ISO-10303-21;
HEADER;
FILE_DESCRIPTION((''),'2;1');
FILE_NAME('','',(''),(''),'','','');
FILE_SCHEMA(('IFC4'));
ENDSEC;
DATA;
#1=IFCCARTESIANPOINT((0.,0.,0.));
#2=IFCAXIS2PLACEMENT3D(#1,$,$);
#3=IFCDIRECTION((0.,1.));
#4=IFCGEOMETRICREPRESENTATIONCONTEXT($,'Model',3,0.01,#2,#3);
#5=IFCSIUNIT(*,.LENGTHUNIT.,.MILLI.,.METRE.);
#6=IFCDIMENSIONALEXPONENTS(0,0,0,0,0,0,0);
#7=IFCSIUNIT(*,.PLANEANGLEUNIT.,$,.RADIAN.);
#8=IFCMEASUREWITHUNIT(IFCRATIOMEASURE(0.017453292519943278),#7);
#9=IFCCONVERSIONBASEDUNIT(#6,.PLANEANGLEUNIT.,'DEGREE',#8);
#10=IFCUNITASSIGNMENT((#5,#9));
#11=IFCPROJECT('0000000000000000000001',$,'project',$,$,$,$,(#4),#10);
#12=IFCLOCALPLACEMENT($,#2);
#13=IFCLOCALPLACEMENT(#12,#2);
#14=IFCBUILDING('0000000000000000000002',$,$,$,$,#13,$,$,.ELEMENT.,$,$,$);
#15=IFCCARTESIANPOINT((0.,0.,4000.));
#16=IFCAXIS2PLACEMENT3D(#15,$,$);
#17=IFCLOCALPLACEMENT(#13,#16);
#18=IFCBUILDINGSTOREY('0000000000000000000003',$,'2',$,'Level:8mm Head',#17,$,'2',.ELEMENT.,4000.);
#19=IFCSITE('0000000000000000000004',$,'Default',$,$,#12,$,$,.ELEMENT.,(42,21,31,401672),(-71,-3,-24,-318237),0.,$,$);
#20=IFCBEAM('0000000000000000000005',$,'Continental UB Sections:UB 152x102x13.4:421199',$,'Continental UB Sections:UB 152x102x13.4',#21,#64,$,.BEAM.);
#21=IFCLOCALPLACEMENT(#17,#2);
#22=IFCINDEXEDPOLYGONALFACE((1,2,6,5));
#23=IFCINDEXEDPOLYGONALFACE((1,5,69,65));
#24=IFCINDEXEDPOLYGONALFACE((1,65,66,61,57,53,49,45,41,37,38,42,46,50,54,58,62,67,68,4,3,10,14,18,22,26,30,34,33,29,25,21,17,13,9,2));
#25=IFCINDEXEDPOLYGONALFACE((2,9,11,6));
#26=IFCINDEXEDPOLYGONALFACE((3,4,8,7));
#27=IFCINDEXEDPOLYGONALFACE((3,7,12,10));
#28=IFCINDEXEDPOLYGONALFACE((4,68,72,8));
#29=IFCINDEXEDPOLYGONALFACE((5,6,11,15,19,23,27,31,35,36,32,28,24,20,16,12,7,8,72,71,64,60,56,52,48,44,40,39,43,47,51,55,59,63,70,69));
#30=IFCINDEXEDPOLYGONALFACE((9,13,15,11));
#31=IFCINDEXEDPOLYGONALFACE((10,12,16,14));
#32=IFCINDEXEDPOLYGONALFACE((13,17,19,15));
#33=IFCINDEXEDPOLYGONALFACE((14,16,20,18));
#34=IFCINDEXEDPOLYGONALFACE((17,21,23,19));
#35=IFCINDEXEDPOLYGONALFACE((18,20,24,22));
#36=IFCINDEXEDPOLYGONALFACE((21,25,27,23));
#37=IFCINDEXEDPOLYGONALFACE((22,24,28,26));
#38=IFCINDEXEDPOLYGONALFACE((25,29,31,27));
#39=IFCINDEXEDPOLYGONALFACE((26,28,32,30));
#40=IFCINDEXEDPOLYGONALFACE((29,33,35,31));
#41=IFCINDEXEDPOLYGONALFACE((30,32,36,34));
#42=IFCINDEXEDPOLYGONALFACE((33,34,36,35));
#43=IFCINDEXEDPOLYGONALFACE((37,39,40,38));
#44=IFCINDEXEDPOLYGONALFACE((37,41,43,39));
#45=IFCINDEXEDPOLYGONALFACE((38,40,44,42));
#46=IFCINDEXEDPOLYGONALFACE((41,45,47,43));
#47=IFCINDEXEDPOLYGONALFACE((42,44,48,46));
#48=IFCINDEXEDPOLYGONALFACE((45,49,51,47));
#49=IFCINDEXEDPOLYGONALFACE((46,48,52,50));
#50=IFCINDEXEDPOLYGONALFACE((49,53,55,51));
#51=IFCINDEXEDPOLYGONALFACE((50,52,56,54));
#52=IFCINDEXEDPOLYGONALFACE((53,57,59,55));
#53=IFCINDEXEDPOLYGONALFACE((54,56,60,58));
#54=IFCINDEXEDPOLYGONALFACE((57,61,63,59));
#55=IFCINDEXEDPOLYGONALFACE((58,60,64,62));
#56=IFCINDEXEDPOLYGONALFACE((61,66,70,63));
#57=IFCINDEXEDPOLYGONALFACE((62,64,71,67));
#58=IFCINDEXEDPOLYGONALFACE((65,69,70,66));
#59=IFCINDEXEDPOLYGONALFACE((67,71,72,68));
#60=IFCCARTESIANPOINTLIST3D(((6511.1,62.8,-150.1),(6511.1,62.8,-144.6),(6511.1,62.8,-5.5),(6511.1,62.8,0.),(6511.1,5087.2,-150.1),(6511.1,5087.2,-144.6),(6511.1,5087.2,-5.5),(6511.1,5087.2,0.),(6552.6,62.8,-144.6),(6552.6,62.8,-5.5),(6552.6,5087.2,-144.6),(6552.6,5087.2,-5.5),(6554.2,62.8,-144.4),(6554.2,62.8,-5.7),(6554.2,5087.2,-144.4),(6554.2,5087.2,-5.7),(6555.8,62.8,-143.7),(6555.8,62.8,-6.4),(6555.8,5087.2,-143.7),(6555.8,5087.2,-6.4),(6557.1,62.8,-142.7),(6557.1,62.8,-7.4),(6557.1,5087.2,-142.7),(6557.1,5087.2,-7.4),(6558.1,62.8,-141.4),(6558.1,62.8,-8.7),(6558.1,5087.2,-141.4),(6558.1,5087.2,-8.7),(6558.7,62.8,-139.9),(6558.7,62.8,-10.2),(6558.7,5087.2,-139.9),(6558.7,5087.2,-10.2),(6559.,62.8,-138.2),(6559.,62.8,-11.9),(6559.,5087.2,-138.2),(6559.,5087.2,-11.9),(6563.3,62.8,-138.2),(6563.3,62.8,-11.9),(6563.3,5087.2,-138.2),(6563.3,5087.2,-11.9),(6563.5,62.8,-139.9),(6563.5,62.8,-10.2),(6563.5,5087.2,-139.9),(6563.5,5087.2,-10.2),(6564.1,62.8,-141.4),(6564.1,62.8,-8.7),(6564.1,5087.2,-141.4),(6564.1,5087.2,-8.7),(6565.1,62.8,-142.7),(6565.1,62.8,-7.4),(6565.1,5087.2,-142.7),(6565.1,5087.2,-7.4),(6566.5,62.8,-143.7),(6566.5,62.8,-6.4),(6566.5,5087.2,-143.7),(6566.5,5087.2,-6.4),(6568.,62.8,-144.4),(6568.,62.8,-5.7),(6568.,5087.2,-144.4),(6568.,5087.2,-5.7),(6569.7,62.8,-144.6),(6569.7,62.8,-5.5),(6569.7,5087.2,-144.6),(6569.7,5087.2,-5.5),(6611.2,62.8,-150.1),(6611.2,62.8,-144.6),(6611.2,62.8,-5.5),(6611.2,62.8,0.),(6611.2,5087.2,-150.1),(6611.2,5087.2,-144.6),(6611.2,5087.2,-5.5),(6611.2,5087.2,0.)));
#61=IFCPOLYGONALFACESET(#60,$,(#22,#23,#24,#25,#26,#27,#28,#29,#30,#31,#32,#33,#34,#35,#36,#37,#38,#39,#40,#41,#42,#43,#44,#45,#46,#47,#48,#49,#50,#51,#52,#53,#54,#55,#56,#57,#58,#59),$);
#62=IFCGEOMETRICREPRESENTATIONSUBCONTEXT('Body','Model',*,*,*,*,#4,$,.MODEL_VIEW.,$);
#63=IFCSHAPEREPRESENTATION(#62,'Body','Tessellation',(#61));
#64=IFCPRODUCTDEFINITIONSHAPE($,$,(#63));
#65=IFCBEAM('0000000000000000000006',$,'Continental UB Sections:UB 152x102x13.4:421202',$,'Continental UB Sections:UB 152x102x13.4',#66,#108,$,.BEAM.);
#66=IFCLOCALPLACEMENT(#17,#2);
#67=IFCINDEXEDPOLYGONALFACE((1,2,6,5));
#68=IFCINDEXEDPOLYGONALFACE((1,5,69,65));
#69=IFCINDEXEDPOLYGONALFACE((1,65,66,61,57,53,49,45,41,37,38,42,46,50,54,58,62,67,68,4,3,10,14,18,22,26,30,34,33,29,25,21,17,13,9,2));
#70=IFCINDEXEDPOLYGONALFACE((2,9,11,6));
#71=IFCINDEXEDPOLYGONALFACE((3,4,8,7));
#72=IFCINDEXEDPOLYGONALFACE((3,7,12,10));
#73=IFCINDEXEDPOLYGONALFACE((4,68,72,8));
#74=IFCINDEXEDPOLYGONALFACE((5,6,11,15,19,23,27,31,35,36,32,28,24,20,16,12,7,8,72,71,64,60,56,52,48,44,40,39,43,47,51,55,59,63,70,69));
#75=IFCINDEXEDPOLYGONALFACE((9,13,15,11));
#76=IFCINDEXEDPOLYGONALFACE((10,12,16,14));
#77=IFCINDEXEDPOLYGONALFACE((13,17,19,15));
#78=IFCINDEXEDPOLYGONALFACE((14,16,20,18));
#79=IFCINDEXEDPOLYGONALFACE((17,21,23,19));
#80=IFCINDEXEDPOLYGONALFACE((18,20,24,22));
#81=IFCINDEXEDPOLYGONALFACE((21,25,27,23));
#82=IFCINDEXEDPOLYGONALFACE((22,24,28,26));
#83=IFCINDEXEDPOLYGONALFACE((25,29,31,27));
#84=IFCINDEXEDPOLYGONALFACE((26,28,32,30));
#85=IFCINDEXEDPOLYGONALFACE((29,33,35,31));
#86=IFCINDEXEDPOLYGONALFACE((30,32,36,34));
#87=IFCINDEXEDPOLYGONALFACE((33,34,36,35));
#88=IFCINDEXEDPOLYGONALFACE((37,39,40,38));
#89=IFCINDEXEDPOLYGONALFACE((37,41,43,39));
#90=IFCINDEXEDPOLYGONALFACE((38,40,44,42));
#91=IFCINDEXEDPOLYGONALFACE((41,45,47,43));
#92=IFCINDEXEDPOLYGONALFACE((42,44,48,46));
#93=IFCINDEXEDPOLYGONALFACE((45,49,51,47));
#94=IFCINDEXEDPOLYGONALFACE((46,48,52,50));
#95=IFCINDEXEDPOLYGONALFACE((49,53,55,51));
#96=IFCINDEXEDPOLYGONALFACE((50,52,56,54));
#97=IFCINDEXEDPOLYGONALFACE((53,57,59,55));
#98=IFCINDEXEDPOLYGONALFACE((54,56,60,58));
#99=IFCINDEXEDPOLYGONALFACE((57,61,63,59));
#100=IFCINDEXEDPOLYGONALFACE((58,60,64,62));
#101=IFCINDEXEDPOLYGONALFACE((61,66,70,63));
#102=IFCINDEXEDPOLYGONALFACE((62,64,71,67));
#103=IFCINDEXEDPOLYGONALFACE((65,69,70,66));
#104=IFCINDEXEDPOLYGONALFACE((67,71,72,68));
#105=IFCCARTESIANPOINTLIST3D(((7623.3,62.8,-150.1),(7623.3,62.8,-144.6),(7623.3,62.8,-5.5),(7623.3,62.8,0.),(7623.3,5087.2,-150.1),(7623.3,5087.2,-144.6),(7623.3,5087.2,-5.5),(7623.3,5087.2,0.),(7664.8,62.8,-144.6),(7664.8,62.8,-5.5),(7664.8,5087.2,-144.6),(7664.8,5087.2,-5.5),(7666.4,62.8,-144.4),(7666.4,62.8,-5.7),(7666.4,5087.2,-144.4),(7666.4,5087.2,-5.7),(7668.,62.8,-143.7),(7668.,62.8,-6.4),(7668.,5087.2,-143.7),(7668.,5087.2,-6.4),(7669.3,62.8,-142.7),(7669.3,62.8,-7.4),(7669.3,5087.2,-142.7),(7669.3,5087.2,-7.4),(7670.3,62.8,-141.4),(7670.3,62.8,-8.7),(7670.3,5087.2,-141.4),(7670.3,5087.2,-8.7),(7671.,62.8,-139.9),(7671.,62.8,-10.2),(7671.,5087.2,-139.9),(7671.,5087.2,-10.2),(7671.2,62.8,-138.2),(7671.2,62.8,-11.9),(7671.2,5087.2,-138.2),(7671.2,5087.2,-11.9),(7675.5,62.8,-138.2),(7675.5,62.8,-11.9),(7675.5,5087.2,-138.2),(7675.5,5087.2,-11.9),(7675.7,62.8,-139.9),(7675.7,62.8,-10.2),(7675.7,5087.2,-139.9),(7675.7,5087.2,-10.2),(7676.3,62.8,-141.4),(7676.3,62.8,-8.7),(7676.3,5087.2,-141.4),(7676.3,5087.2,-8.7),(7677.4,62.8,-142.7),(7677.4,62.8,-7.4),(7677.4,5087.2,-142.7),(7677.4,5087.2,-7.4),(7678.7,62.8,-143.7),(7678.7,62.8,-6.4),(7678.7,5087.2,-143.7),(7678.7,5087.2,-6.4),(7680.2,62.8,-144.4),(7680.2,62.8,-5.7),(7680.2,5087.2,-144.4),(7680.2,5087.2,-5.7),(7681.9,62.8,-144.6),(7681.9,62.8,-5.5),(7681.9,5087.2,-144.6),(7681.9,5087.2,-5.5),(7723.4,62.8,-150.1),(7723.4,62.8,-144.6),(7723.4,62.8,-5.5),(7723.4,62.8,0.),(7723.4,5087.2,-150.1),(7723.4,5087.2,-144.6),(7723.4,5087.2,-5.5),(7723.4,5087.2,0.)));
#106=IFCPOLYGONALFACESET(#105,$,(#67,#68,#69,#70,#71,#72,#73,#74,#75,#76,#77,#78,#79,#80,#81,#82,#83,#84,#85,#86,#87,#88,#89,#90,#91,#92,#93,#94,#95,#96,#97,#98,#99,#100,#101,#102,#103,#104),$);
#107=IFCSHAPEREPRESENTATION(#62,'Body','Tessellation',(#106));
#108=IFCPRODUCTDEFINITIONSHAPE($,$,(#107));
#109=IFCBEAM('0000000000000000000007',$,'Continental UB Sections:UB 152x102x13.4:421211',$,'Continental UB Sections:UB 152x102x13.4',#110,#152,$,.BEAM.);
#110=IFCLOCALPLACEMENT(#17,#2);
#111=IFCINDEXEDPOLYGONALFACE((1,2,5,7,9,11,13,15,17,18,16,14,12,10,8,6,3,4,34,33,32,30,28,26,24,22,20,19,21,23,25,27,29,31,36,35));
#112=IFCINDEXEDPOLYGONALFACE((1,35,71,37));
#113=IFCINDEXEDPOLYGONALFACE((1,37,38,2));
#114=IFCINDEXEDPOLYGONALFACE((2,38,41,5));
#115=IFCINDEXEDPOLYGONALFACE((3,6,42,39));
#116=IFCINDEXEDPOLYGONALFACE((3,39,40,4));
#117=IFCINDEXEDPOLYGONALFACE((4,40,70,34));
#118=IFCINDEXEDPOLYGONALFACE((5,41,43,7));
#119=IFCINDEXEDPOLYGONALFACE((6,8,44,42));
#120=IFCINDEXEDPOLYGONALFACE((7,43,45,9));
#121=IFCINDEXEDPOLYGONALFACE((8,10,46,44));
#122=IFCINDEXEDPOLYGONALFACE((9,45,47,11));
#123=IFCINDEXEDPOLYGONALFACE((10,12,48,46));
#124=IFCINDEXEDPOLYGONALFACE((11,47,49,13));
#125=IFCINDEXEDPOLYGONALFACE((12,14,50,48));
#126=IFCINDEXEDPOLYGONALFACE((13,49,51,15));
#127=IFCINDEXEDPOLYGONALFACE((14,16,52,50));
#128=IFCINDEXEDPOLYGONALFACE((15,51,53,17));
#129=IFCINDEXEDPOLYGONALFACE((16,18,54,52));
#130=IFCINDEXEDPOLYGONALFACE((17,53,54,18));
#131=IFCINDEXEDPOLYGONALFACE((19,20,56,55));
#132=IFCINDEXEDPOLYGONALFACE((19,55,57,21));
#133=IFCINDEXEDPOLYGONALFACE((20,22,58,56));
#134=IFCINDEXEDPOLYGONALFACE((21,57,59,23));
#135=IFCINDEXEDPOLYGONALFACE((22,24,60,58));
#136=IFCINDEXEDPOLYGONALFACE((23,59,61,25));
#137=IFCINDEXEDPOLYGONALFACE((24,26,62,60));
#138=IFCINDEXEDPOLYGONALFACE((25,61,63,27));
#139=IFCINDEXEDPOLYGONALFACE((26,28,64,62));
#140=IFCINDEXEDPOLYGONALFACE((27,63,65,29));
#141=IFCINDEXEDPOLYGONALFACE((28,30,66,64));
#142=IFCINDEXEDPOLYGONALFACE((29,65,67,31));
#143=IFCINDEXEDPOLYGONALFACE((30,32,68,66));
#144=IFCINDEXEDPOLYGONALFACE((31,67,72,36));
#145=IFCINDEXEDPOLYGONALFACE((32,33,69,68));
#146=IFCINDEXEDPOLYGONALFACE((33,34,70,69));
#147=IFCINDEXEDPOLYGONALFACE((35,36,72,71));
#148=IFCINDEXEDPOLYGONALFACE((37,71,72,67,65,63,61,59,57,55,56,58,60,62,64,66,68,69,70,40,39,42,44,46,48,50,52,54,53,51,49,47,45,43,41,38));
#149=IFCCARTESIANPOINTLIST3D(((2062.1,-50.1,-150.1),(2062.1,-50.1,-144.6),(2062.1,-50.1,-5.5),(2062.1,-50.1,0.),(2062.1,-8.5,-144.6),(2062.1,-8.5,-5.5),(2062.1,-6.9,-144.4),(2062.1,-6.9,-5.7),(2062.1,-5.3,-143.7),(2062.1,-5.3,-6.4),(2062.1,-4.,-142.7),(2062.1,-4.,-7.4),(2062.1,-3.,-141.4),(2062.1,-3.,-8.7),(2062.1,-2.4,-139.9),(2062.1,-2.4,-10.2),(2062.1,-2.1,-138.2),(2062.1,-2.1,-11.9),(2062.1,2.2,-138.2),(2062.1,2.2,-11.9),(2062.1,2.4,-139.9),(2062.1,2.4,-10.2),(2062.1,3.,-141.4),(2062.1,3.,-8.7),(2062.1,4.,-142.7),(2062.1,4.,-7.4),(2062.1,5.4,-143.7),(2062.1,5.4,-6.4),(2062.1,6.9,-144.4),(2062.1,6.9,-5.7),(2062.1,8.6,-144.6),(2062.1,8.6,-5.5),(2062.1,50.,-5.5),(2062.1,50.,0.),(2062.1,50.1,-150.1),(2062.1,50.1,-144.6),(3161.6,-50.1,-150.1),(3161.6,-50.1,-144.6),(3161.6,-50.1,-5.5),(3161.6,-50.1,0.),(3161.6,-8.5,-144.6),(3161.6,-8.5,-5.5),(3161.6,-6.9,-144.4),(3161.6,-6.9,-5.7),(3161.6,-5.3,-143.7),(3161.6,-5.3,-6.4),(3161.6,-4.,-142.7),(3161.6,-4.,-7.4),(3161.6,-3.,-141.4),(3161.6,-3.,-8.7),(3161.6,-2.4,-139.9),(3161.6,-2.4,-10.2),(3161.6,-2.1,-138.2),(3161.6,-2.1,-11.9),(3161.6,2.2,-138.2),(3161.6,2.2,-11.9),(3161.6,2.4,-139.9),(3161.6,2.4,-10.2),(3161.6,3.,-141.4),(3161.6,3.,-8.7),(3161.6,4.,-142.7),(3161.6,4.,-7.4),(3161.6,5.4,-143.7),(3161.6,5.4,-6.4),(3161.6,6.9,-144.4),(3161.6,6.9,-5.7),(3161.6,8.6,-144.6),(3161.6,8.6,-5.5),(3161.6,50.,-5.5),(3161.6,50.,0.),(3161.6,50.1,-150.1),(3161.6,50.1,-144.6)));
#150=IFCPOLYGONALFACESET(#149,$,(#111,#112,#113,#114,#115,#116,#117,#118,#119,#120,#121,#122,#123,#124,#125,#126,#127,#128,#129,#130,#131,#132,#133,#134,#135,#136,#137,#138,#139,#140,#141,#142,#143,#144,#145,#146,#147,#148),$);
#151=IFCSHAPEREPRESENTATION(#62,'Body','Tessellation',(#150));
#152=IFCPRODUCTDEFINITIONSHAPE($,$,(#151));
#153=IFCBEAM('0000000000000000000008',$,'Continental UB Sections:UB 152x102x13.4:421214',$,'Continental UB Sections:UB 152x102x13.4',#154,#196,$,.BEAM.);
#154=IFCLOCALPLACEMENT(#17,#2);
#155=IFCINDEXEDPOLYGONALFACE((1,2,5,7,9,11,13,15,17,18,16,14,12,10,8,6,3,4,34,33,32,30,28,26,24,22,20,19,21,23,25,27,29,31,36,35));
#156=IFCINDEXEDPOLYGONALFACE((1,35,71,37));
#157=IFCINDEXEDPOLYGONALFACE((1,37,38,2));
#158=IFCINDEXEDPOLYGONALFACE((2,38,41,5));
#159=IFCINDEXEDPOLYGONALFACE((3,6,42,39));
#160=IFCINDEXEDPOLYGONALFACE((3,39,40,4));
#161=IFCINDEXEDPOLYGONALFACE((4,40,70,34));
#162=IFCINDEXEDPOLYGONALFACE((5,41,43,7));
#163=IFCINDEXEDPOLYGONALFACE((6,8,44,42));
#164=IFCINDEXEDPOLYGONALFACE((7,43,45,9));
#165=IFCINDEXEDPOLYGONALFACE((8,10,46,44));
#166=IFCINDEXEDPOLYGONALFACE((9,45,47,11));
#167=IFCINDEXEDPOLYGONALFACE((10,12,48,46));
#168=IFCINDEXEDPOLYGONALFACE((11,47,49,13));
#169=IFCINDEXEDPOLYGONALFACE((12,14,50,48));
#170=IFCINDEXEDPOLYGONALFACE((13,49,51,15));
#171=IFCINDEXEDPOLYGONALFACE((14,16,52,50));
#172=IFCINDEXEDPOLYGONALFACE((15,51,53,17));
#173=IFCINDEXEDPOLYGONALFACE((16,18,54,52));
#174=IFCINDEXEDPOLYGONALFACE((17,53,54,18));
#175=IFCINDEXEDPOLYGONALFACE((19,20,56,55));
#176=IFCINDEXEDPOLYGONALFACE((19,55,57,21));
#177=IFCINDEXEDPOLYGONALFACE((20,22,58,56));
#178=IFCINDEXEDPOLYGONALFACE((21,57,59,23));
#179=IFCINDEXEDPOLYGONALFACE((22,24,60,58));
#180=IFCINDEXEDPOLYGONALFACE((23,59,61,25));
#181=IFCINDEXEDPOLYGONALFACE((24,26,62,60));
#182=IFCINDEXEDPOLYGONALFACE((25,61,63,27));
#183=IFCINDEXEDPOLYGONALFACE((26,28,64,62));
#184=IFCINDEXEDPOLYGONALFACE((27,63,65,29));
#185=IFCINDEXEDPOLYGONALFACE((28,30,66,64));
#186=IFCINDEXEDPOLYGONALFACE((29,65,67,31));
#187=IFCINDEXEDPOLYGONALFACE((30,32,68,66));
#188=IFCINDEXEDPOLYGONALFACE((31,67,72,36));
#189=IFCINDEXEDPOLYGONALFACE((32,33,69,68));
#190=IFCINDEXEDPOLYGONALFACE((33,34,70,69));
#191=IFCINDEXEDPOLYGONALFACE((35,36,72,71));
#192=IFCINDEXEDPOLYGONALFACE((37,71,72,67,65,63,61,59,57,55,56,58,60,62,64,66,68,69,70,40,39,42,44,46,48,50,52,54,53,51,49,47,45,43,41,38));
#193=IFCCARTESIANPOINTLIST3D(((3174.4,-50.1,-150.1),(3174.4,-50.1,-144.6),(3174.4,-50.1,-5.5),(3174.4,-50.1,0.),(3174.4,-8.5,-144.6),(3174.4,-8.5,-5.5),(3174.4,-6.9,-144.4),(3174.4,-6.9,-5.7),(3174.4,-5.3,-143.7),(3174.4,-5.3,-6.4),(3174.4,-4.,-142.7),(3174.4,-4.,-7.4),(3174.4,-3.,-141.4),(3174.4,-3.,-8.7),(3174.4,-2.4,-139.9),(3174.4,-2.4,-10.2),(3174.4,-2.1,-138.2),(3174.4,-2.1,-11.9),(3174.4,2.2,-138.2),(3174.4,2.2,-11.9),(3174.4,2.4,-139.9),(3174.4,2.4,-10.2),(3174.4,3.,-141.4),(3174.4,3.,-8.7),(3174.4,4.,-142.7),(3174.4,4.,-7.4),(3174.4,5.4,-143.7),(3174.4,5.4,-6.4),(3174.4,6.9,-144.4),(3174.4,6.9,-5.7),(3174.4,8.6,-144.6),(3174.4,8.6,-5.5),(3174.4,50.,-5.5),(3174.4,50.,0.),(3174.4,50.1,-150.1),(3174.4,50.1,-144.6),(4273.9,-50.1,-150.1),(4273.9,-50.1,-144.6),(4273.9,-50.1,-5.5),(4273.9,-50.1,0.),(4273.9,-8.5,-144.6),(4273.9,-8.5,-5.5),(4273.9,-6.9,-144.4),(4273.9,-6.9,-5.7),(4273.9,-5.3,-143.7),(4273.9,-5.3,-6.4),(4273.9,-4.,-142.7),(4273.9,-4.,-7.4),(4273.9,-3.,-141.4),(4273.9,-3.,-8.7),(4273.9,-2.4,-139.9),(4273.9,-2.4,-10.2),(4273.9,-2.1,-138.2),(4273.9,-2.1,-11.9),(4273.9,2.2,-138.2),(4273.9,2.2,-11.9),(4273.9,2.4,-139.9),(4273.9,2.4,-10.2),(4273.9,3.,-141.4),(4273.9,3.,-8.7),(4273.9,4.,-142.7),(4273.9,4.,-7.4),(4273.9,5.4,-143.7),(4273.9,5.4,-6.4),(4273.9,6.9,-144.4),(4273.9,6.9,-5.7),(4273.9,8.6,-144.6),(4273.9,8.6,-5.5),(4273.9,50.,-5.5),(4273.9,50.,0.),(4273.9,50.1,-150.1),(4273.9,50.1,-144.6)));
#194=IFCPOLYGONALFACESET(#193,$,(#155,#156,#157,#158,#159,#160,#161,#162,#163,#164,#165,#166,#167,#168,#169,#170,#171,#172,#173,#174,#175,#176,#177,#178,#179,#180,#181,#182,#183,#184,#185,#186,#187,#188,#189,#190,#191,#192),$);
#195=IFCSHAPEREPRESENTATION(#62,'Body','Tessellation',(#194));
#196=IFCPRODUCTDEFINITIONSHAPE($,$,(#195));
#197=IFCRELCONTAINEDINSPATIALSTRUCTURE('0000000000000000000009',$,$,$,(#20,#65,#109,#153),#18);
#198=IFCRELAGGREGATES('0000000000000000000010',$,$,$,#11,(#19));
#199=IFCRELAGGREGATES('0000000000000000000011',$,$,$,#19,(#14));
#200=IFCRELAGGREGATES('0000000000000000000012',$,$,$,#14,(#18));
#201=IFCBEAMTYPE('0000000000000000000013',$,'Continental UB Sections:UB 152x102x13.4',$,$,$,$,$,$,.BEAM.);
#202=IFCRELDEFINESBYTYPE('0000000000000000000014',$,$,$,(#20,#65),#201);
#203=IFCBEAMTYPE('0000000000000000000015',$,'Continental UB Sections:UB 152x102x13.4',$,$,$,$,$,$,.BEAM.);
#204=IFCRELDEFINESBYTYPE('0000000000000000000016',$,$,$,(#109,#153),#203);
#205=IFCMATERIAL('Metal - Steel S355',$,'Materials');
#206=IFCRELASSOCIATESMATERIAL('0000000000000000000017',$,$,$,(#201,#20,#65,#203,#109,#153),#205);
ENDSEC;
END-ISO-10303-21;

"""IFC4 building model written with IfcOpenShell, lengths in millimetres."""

from ifc_helpers import new_model, entity, si_unit, converted_unit, direction, frame, origin, place, context, subcontext, project, spatial, line, arc, indexed_curve, outline, extrude, source, transform, mapped, material, type_object, type_shapes, element, save


model = new_model("IFC4")

# Units and contexts
model_context = context("Model", 3, precision=0.01, world=origin(), true_north=direction((0.0, 1.0)))
body_context = subcontext(model_context, "Body", "Model", "MODEL_VIEW")
ifc_project = project(units=[si_unit("LENGTHUNIT", "METRE", prefix="MILLI"), converted_unit("PLANEANGLEUNIT", "DEGREE", entity("IfcRatioMeasure", 0.017453292519943278), si_unit("PLANEANGLEUNIT", "RADIAN"), dimensions=[0, 0, 0, 0, 0, 0, 0])], contexts=[model_context])

# Site, building, storey
site_placement = place(None, origin())
site = spatial("IfcSite", under=ifc_project, at=site_placement, Name="Default", CompositionType="ELEMENT", RefLatitude=(42, 21, 31, 401672), RefLongitude=(-71, -3, -24, -318237), RefElevation=0.0)
building_placement = place(site_placement, origin())
building = spatial("IfcBuilding", under=site, at=building_placement, CompositionType="ELEMENT")
storey_placement = place(building_placement, frame((0.0, 0.0, 4000.0)))
storey = spatial("IfcBuildingStorey", under=building, at=storey_placement, Name="2", ObjectType="Level:8mm Head", LongName="2", CompositionType="ELEMENT", Elevation=4000.0)

# Beams
ifc_material_1 = material(Name="Metal - Steel S355", Category="Materials")
beam_type_1 = type_object("IfcBeamType", Name="Continental UB Sections:UB 152x102x13.4", PredefinedType="BEAM", material=ifc_material_1)
shared_shape_1 = source(origin(), body_context, "Body", "SweptSolid", [
    extrude(outline(indexed_curve([(-75.0, -50.1), (-69.6, -50.1), (-69.6, -8.5), (-67.7, -4.0), (-63.2, -2.1), (63.1, -2.1), (67.7, -4.0), (69.5, -8.5), (69.5, -50.1), (75.1, -50.1), (75.1, 50.1), (69.5, 50.1), (69.5, 8.6), (67.7, 4.0), (63.1, 2.2), (-63.2, 2.2), (-67.7, 4.0), (-69.6, 8.6), (-69.6, 50.0), (-75.0, 50.0)], segments=[line(1, 2, 3), arc(3, 4, 5), line(5, 6), arc(6, 7, 8), line(8, 9, 10, 11, 12, 13), arc(13, 14, 15), line(15, 16), arc(16, 17, 18), line(18, 19, 20, 1)], self_intersect=False)), frame((-2487.2, 0.0, 0.0), z_axis=(1.0, 0.0, 0.0), x_axis=(0.0, 0.0, -1.0)), (0.0, 0.0, 1.0), 5024.4),
])
type_shapes(beam_type_1, [shared_shape_1])
for number, where, z_axis, x_axis, name in (
    (1, (6561.1, 2550.0, -75.1), (0.0, 0.0, 1.0), (0.0, 1.0, 0.0), "Continental UB Sections:UB 152x102x13.4:421199"),
    (2, (7673.3, 2550.0, -75.1), (0.0, 0.0, 1.0), (0.0, 1.0, 0.0), "Continental UB Sections:UB 152x102x13.4:421202"),
):
    element("IfcBeam", number, at=place(storey_placement, frame(where, z_axis=z_axis, x_axis=x_axis)), inside=storey, type_object=beam_type_1, material=ifc_material_1, Name=name, ObjectType="Continental UB Sections:UB 152x102x13.4", PredefinedType="BEAM", context=body_context, shape_type="MappedRepresentation", body=[
        mapped(shared_shape_1, transform((0.0, 0.0, 0.0), scale=1.0)),
    ])
beam_type_2 = type_object("IfcBeamType", Name="Continental UB Sections:UB 152x102x13.4", PredefinedType="BEAM", material=ifc_material_1)
shared_shape_2 = source(origin(), body_context, "Body", "SweptSolid", [
    extrude(outline(indexed_curve([(-75.0, -50.1), (-69.6, -50.1), (-69.6, -8.5), (-67.7, -4.0), (-63.2, -2.1), (63.1, -2.1), (67.7, -4.0), (69.5, -8.5), (69.5, -50.1), (75.1, -50.1), (75.1, 50.1), (69.5, 50.1), (69.5, 8.6), (67.7, 4.0), (63.1, 2.2), (-63.2, 2.2), (-67.7, 4.0), (-69.6, 8.6), (-69.6, 50.0), (-75.0, 50.0)], segments=[line(1, 2, 3), arc(3, 4, 5), line(5, 6), arc(6, 7, 8), line(8, 9, 10, 11, 12, 13), arc(13, 14, 15), line(15, 16), arc(16, 17, 18), line(18, 19, 20, 1)], self_intersect=False)), frame((-606.2, 0.0, 0.0), z_axis=(1.0, 0.0, 0.0), x_axis=(0.0, 0.0, -1.0)), (0.0, 0.0, 1.0), 1099.5),
])
type_shapes(beam_type_2, [shared_shape_2])
for number, where, name in (
    (3, (2668.3, 0.0, -75.1), "Continental UB Sections:UB 152x102x13.4:421211"),
    (4, (3780.6, 0.0, -75.1), "Continental UB Sections:UB 152x102x13.4:421214"),
):
    element("IfcBeam", number, at=place(storey_placement, frame(where)), inside=storey, type_object=beam_type_2, material=ifc_material_1, Name=name, ObjectType="Continental UB Sections:UB 152x102x13.4", PredefinedType="BEAM", context=body_context, shape_type="MappedRepresentation", body=[
        mapped(shared_shape_2, transform((0.0, 0.0, 0.0), scale=1.0)),
    ])

save(model, "model.ifc")
